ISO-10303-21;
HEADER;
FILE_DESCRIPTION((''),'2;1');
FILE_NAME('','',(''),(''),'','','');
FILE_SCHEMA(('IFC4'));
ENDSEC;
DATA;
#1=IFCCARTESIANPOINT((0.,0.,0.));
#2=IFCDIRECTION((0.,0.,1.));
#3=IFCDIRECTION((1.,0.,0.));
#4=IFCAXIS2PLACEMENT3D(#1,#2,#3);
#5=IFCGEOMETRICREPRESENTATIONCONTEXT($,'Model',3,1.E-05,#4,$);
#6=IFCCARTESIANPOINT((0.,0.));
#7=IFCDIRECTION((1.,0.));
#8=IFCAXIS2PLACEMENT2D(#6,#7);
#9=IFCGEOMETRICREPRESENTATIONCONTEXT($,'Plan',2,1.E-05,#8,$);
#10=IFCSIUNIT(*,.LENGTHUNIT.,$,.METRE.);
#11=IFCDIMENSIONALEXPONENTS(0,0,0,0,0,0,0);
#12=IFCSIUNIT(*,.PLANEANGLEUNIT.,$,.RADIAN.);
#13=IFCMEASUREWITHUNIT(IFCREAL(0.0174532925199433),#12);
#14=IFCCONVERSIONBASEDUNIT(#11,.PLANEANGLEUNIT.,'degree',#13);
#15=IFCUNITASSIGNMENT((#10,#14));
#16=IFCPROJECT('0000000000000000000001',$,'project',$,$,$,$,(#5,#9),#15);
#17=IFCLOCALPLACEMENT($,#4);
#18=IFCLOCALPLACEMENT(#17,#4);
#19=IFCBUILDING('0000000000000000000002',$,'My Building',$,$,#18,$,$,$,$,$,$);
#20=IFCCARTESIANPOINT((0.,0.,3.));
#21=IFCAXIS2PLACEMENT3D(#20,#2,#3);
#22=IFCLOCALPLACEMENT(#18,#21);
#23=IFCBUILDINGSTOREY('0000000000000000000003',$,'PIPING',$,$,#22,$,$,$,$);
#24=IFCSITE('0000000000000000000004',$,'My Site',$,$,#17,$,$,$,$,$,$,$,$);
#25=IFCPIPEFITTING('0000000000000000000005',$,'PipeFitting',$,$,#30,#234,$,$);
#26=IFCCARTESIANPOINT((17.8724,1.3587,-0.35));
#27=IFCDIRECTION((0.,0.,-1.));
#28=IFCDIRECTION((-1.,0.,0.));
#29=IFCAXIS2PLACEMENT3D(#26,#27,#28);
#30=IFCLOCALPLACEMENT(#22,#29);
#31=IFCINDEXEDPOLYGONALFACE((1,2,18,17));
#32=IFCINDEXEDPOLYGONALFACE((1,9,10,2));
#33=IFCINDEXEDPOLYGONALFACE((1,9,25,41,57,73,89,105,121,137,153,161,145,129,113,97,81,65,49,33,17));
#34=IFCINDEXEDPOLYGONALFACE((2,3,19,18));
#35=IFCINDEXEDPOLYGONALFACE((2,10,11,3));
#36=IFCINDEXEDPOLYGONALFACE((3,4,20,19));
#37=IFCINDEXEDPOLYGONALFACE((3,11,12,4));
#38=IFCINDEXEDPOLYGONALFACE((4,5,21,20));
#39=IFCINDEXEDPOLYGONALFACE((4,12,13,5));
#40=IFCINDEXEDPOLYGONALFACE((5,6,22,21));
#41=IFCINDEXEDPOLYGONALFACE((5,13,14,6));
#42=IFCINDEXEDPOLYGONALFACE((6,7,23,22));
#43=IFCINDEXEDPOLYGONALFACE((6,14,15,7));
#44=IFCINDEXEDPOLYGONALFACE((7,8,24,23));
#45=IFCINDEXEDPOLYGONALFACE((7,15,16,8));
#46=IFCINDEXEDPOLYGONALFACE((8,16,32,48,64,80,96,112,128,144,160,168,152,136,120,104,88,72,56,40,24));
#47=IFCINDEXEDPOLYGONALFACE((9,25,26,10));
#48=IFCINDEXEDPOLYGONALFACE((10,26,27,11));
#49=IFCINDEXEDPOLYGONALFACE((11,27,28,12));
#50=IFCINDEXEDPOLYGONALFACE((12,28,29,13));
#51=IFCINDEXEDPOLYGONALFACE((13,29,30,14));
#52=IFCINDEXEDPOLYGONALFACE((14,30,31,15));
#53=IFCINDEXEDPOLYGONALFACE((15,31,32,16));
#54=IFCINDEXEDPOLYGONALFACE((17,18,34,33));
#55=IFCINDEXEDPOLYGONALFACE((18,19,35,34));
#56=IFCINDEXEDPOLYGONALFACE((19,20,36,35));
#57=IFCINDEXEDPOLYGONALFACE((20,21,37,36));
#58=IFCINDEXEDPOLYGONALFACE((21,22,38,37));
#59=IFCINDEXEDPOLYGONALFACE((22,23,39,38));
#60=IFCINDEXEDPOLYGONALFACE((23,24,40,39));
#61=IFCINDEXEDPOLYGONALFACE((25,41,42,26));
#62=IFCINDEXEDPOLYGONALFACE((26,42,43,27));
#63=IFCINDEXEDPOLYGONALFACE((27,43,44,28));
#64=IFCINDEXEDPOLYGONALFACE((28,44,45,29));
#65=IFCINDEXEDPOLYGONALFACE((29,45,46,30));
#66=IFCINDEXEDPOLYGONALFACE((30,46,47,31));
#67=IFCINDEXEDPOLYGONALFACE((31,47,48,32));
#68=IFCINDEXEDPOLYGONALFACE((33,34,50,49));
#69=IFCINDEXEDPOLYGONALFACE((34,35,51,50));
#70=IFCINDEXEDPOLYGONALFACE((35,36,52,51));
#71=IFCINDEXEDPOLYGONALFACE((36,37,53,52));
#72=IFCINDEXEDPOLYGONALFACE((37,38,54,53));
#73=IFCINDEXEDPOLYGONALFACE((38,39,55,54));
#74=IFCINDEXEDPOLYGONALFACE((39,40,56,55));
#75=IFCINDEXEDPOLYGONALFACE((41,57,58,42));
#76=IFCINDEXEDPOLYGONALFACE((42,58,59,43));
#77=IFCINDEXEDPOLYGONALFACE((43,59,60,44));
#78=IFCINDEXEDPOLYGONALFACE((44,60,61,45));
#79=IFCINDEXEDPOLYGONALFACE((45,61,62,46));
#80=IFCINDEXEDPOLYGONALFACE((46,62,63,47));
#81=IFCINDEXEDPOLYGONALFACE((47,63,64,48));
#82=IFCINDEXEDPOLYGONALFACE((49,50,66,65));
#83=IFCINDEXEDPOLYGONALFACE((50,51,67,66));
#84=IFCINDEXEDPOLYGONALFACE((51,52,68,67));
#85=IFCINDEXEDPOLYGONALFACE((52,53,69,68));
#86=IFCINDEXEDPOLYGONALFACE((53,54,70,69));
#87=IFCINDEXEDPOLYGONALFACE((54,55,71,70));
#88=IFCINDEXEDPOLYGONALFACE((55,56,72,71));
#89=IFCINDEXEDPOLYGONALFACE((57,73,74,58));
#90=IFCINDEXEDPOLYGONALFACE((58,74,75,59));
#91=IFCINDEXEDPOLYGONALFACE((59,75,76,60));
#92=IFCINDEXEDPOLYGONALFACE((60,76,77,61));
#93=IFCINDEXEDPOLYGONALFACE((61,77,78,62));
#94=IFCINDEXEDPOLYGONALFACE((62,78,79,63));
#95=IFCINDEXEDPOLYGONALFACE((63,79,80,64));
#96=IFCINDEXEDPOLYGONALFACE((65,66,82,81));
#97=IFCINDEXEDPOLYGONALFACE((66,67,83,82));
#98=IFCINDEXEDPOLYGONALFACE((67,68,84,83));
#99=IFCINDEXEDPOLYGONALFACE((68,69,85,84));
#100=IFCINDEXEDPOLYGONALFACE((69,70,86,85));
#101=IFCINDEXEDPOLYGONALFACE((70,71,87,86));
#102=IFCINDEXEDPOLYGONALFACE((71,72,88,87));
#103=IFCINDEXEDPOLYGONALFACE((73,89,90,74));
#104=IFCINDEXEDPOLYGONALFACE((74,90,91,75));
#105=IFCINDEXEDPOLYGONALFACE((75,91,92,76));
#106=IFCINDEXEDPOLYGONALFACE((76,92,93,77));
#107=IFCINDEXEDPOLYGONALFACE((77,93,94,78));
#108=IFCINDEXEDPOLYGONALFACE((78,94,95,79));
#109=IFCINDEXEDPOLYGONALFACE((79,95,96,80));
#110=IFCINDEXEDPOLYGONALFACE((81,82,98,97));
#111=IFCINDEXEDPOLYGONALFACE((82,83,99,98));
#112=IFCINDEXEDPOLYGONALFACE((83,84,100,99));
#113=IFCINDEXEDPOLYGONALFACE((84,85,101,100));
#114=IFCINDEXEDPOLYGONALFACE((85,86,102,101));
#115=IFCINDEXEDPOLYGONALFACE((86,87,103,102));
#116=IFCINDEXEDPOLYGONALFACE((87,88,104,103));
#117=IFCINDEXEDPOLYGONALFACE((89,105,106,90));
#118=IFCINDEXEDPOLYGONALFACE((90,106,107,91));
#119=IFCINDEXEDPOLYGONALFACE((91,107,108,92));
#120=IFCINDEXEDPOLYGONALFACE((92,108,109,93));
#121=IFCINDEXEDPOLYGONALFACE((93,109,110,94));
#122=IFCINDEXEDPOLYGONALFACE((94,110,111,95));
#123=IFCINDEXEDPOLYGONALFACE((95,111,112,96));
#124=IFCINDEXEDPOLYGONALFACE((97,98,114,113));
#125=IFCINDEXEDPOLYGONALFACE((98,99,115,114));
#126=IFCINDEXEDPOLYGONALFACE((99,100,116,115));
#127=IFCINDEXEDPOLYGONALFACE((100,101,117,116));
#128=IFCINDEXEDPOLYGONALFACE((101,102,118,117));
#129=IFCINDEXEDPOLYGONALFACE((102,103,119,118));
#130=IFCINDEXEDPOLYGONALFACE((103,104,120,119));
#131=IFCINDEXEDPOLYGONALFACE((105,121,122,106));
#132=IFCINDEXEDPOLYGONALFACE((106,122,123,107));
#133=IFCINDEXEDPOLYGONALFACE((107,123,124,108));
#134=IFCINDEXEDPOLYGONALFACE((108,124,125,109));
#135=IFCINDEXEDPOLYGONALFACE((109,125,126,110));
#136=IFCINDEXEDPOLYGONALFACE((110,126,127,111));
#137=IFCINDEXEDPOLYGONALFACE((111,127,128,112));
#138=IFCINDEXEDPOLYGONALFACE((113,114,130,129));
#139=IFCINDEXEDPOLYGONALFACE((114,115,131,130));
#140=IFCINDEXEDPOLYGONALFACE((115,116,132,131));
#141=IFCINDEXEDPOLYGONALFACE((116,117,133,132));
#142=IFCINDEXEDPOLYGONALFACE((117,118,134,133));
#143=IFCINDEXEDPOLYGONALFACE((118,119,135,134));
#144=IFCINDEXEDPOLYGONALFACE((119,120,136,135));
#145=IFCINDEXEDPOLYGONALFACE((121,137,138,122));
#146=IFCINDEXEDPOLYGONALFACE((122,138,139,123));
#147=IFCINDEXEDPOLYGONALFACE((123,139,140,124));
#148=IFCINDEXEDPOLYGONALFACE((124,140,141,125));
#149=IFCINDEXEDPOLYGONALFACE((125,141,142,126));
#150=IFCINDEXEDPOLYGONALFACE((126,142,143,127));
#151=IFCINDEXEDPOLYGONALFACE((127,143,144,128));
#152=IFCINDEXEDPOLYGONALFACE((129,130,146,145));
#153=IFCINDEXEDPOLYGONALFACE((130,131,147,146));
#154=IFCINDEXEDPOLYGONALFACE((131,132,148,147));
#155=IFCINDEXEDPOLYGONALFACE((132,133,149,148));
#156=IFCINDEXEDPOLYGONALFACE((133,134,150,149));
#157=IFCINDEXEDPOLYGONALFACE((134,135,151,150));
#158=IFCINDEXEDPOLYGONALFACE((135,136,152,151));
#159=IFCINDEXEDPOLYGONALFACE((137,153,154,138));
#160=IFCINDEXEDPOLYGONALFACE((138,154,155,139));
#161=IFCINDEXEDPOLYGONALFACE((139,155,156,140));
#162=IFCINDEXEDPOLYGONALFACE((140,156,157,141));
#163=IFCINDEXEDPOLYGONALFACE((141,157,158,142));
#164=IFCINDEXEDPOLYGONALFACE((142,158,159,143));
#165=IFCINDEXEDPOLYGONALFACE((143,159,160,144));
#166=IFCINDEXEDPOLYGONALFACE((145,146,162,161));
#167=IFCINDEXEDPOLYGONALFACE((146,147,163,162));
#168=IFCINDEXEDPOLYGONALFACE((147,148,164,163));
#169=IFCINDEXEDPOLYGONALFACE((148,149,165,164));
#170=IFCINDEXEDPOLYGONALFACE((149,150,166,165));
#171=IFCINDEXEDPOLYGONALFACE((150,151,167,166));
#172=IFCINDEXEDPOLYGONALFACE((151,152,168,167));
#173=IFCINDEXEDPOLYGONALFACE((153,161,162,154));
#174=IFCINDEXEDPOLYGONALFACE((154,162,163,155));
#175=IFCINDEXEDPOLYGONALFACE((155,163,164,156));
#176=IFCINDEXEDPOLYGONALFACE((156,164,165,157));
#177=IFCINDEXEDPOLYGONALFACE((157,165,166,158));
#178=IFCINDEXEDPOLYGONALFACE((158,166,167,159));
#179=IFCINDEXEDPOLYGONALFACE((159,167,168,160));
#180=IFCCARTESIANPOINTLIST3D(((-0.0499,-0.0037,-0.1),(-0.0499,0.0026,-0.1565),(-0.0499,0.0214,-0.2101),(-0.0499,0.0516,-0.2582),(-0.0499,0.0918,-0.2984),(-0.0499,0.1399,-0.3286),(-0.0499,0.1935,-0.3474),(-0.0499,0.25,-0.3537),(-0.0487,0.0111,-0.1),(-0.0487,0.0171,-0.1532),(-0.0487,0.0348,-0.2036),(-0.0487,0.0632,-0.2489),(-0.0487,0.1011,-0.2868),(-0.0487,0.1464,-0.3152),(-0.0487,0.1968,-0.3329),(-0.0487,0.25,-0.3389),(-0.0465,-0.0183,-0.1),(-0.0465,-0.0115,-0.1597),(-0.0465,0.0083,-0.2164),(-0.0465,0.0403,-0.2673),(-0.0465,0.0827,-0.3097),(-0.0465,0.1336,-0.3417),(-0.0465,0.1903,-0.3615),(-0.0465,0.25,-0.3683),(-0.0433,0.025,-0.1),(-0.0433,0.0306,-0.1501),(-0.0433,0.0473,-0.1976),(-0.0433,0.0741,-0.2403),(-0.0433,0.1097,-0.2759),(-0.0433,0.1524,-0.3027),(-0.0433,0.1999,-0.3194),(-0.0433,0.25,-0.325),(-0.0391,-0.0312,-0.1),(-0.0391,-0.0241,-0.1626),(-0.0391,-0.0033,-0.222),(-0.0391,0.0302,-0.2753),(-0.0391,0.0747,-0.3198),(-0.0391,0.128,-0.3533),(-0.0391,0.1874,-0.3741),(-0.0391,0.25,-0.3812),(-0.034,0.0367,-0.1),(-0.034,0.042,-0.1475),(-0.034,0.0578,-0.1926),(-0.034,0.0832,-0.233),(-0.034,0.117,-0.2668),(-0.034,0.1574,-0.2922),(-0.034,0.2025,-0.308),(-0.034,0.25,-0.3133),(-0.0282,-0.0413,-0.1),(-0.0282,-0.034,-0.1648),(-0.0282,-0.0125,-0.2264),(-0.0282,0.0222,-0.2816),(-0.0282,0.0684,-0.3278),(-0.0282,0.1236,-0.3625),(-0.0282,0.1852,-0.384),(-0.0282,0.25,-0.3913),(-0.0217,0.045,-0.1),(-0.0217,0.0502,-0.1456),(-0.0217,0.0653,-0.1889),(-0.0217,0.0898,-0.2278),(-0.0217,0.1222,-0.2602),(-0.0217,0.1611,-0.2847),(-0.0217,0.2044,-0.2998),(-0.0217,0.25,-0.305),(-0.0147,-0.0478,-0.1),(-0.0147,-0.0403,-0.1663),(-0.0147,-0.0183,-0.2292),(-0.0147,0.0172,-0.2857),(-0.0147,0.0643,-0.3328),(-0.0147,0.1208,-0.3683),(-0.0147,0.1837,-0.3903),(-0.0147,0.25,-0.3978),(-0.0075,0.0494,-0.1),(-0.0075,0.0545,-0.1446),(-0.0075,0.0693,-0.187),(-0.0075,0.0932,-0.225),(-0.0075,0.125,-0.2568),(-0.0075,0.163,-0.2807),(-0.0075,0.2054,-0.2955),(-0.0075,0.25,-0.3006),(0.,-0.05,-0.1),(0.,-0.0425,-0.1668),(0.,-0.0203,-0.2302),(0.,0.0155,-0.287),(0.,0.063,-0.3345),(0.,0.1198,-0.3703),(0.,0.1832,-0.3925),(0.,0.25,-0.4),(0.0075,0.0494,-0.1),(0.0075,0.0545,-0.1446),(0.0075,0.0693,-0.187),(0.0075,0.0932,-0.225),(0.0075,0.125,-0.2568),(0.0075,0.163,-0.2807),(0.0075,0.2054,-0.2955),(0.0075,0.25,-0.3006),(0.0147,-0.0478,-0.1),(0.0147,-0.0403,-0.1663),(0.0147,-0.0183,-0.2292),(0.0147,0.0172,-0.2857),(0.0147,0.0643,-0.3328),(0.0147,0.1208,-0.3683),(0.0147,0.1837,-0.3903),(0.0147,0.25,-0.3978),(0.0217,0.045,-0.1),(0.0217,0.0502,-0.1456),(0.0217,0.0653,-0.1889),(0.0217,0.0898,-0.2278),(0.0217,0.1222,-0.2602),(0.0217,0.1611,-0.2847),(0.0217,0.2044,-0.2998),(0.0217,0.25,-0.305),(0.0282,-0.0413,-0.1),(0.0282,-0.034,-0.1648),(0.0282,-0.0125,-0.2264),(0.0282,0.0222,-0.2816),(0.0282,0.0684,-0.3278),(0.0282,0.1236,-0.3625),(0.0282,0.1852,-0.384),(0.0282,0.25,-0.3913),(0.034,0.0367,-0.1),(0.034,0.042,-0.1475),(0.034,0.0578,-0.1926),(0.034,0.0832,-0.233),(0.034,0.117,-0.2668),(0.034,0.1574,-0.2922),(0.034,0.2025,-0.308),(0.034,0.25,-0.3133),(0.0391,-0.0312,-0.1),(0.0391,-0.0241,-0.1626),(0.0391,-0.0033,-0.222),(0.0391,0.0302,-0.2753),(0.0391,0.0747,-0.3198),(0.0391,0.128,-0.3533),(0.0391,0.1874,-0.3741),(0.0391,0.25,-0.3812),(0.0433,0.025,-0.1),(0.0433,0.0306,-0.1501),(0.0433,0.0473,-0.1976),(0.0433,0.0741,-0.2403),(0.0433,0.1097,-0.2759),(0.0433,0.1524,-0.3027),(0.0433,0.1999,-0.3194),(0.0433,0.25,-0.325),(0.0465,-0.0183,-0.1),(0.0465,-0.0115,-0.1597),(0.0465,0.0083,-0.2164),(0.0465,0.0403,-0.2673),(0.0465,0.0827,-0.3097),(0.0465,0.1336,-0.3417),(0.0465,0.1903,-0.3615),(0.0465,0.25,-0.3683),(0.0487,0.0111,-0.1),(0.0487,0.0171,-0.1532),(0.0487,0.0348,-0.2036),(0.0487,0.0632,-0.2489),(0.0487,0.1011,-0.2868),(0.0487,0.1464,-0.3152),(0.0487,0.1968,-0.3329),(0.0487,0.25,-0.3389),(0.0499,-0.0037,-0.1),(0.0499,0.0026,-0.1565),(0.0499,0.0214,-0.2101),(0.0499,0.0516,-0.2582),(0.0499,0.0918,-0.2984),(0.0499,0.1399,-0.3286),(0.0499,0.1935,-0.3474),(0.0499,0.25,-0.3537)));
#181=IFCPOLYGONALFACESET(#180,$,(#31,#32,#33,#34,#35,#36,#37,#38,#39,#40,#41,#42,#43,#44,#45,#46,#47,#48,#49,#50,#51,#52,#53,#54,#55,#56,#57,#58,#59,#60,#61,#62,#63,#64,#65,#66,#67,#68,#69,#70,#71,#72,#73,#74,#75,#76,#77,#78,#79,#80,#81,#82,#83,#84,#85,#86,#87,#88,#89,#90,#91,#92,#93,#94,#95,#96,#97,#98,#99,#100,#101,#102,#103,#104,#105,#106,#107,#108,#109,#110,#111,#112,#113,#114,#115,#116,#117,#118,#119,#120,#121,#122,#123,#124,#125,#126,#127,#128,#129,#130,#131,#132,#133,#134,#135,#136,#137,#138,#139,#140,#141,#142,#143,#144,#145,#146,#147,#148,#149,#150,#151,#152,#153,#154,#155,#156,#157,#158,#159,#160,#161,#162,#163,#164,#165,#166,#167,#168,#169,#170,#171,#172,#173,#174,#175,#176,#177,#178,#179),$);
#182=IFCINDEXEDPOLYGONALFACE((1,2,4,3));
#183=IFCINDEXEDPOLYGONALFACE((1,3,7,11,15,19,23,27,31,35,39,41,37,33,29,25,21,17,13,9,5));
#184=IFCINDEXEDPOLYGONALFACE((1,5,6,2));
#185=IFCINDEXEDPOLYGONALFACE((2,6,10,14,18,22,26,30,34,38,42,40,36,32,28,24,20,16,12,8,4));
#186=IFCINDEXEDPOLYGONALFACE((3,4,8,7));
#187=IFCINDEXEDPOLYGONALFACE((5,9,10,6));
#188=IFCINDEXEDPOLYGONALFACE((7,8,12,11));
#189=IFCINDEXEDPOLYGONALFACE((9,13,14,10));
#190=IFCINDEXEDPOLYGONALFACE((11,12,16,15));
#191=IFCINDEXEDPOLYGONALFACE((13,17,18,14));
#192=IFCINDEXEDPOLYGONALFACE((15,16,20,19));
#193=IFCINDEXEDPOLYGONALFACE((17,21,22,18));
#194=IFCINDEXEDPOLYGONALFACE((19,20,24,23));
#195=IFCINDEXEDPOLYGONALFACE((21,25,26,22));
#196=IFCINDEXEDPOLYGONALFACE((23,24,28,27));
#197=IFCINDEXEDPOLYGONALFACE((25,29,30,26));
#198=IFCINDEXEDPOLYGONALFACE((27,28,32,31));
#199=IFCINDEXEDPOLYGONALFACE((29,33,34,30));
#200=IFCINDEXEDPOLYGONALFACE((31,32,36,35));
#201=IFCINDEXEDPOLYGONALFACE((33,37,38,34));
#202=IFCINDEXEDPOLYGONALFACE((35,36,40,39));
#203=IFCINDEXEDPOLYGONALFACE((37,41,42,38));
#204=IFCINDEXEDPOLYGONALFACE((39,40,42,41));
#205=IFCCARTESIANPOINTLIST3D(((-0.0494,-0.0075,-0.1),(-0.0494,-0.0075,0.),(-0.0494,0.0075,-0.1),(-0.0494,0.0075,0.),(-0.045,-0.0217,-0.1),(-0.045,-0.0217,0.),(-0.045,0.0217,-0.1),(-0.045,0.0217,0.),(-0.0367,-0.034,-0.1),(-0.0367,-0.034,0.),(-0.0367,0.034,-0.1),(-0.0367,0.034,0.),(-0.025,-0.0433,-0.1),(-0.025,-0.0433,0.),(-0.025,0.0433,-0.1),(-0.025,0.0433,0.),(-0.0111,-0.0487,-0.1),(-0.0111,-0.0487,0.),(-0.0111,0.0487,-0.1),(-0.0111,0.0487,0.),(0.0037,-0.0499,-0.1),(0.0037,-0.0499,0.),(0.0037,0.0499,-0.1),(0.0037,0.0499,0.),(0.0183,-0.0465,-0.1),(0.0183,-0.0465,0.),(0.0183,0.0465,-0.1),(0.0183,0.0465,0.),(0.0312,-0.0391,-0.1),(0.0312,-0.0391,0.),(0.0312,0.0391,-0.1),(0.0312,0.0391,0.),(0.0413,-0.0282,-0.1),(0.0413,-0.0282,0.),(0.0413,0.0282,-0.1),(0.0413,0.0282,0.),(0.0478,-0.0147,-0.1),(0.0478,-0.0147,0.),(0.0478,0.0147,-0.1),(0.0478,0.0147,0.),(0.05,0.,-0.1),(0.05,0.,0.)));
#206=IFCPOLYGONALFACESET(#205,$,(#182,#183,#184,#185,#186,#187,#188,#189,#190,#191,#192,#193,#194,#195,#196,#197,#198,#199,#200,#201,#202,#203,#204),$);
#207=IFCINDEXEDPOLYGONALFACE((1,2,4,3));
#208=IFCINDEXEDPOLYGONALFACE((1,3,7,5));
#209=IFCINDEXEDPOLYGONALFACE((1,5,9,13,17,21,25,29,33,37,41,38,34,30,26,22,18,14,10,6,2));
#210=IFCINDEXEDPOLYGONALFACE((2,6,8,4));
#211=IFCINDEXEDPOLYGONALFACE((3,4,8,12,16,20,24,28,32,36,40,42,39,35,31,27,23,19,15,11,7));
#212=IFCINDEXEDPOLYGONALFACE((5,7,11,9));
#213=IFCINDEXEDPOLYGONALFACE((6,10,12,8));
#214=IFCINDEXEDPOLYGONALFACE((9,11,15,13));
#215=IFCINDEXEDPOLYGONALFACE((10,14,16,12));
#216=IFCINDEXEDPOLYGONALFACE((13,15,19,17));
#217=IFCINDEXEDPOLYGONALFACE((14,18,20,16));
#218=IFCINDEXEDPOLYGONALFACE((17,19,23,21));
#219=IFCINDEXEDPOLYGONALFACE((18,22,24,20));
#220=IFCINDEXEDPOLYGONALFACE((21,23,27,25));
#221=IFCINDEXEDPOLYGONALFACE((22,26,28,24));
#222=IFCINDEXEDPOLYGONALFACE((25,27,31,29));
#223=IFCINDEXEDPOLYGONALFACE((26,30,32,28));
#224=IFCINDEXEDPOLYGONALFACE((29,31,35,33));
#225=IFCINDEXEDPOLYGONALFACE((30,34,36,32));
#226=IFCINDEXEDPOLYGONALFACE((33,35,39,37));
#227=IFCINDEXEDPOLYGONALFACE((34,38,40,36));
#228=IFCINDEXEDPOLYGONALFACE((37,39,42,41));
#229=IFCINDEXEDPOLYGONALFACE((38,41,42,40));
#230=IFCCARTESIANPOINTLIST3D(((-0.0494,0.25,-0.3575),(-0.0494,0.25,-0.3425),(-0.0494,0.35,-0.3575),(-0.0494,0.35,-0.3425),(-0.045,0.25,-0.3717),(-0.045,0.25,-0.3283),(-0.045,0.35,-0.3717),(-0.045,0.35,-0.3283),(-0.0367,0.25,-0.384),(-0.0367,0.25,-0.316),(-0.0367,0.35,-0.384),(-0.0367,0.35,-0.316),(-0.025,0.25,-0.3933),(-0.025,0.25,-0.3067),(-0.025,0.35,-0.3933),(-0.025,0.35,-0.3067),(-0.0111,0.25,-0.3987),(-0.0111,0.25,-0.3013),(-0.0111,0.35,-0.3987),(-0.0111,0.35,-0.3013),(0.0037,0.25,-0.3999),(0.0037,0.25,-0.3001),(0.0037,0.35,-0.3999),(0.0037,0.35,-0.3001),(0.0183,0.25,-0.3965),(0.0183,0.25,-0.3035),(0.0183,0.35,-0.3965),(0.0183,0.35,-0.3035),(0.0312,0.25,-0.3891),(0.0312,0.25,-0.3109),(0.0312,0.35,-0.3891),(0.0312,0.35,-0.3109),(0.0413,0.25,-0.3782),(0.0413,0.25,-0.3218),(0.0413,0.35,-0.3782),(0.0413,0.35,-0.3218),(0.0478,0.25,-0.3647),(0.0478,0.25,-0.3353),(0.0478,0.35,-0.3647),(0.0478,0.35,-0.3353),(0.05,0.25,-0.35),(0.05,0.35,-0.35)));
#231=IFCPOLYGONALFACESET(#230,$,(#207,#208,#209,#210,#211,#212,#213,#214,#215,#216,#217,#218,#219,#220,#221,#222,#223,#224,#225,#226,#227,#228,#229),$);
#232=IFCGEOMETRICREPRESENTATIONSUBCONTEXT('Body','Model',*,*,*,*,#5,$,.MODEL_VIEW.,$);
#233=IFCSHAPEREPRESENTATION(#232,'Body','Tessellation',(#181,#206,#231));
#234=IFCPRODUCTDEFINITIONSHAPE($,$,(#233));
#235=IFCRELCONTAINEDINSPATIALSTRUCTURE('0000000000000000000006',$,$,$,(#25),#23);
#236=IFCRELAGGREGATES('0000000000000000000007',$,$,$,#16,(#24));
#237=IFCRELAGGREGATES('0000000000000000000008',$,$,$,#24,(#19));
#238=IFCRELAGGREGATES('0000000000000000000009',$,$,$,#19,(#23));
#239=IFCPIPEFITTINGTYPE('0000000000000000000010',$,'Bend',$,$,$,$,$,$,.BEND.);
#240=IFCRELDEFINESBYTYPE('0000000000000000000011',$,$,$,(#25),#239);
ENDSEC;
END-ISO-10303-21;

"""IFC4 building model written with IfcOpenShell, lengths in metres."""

from ifc_helpers import new_model, entity, si_unit, converted_unit, frame, origin_with_axes, origin_2d_with_axis, place, context, subcontext, project, spatial, line, indexed_curve, circle, outline, extrude, source, transform, mapped, type_object, type_shapes, element, save


model = new_model("IFC4")

# Units and contexts
model_context = context("Model", 3, precision=1e-05, world=origin_with_axes())
plan_context = context("Plan", 2, precision=1e-05, world=origin_2d_with_axis())
body_context = subcontext(model_context, "Body", "Model", "MODEL_VIEW")
ifc_project = project(units=[si_unit("LENGTHUNIT", "METRE"), converted_unit("PLANEANGLEUNIT", "degree", entity("IfcReal", 0.0174532925199433), si_unit("PLANEANGLEUNIT", "RADIAN"), dimensions=[0, 0, 0, 0, 0, 0, 0])], contexts=[model_context, plan_context])

# Site, building, storey
site_placement = place(None, origin_with_axes())
site = spatial("IfcSite", under=ifc_project, at=site_placement, Name="My Site")
building_placement = place(site_placement, origin_with_axes())
building = spatial("IfcBuilding", under=site, at=building_placement, Name="My Building")
storey_placement = place(building_placement, frame((0.0, 0.0, 3.0), z_axis=(0.0, 0.0, 1.0), x_axis=(1.0, 0.0, 0.0)))
storey = spatial("IfcBuildingStorey", under=building, at=storey_placement, Name="PIPING")

# Shared definitions
pipe_fitting_type_1 = type_object("IfcPipeFittingType", Name="Bend", PredefinedType="BEND")
shared_shape = source(origin_with_axes(), body_context, "Body", "SolidModel", [
    entity("IfcSweptDiskSolid", entity("IfcIndexedPolyCurve", entity("IfcCartesianPointList3D", [[0.0, 0.0, -0.1], [0.0, 0.0732, -0.2768], [0.0, 0.25, -0.35]]), [entity("IfcArcIndex", [1, 2, 3])]), 0.05),
    extrude(circle(Radius=0.05), origin_with_axes(), (0.0, 0.0, -1.0), 0.1),
    extrude(circle(Radius=0.05), frame((0.0, 0.25, -0.35), z_axis=(0.0, 1.0, 0.0), x_axis=(1.0, 0.0, 0.0)), (0.0, 0.0, 1.0), 0.1),
])
type_shapes(pipe_fitting_type_1, [shared_shape])

# Pipe fitting, opening
pipe_fitting_1_placement = place(storey_placement, frame((17.8724, 1.3587, -0.35), z_axis=(0.0, 0.0, -1.0), x_axis=(-1.0, 0.0, 0.0)))
pipe_fitting_1 = element("IfcPipeFitting", 1, at=pipe_fitting_1_placement, inside=storey, type_object=pipe_fitting_type_1, Name="PipeFitting", context=body_context, shape_type="MappedRepresentation", body=[
    mapped(shared_shape, transform((0.0, 0.0, 0.0), x_axis=(1.0, 0.0, 0.0), y_axis=(0.0, 1.0, 0.0), z_axis=(0.0, 0.0, 1.0), scale=1.0)),
])
opening_1_placement = place(pipe_fitting_1_placement, frame((17.8724, -1.3587, 2.65), z_axis=(0.0, 0.0, -1.0), x_axis=(-1.0, 0.0, 0.0)))
element("IfcOpeningElement", 2, at=opening_1_placement, cuts=pipe_fitting_1, PredefinedType="OPENING", context=body_context, shape_type="SweptSolid", body=[
    extrude(outline(indexed_curve([(0.0, 0.0), (0.5, 0.0), (0.5, 0.5), (0.0, 0.5)], segments=[line(1, 2, 3, 4, 1)])), origin_with_axes(), (0.0, 0.0, 1.0), 0.5),
])

save(model, "model.ifc")
